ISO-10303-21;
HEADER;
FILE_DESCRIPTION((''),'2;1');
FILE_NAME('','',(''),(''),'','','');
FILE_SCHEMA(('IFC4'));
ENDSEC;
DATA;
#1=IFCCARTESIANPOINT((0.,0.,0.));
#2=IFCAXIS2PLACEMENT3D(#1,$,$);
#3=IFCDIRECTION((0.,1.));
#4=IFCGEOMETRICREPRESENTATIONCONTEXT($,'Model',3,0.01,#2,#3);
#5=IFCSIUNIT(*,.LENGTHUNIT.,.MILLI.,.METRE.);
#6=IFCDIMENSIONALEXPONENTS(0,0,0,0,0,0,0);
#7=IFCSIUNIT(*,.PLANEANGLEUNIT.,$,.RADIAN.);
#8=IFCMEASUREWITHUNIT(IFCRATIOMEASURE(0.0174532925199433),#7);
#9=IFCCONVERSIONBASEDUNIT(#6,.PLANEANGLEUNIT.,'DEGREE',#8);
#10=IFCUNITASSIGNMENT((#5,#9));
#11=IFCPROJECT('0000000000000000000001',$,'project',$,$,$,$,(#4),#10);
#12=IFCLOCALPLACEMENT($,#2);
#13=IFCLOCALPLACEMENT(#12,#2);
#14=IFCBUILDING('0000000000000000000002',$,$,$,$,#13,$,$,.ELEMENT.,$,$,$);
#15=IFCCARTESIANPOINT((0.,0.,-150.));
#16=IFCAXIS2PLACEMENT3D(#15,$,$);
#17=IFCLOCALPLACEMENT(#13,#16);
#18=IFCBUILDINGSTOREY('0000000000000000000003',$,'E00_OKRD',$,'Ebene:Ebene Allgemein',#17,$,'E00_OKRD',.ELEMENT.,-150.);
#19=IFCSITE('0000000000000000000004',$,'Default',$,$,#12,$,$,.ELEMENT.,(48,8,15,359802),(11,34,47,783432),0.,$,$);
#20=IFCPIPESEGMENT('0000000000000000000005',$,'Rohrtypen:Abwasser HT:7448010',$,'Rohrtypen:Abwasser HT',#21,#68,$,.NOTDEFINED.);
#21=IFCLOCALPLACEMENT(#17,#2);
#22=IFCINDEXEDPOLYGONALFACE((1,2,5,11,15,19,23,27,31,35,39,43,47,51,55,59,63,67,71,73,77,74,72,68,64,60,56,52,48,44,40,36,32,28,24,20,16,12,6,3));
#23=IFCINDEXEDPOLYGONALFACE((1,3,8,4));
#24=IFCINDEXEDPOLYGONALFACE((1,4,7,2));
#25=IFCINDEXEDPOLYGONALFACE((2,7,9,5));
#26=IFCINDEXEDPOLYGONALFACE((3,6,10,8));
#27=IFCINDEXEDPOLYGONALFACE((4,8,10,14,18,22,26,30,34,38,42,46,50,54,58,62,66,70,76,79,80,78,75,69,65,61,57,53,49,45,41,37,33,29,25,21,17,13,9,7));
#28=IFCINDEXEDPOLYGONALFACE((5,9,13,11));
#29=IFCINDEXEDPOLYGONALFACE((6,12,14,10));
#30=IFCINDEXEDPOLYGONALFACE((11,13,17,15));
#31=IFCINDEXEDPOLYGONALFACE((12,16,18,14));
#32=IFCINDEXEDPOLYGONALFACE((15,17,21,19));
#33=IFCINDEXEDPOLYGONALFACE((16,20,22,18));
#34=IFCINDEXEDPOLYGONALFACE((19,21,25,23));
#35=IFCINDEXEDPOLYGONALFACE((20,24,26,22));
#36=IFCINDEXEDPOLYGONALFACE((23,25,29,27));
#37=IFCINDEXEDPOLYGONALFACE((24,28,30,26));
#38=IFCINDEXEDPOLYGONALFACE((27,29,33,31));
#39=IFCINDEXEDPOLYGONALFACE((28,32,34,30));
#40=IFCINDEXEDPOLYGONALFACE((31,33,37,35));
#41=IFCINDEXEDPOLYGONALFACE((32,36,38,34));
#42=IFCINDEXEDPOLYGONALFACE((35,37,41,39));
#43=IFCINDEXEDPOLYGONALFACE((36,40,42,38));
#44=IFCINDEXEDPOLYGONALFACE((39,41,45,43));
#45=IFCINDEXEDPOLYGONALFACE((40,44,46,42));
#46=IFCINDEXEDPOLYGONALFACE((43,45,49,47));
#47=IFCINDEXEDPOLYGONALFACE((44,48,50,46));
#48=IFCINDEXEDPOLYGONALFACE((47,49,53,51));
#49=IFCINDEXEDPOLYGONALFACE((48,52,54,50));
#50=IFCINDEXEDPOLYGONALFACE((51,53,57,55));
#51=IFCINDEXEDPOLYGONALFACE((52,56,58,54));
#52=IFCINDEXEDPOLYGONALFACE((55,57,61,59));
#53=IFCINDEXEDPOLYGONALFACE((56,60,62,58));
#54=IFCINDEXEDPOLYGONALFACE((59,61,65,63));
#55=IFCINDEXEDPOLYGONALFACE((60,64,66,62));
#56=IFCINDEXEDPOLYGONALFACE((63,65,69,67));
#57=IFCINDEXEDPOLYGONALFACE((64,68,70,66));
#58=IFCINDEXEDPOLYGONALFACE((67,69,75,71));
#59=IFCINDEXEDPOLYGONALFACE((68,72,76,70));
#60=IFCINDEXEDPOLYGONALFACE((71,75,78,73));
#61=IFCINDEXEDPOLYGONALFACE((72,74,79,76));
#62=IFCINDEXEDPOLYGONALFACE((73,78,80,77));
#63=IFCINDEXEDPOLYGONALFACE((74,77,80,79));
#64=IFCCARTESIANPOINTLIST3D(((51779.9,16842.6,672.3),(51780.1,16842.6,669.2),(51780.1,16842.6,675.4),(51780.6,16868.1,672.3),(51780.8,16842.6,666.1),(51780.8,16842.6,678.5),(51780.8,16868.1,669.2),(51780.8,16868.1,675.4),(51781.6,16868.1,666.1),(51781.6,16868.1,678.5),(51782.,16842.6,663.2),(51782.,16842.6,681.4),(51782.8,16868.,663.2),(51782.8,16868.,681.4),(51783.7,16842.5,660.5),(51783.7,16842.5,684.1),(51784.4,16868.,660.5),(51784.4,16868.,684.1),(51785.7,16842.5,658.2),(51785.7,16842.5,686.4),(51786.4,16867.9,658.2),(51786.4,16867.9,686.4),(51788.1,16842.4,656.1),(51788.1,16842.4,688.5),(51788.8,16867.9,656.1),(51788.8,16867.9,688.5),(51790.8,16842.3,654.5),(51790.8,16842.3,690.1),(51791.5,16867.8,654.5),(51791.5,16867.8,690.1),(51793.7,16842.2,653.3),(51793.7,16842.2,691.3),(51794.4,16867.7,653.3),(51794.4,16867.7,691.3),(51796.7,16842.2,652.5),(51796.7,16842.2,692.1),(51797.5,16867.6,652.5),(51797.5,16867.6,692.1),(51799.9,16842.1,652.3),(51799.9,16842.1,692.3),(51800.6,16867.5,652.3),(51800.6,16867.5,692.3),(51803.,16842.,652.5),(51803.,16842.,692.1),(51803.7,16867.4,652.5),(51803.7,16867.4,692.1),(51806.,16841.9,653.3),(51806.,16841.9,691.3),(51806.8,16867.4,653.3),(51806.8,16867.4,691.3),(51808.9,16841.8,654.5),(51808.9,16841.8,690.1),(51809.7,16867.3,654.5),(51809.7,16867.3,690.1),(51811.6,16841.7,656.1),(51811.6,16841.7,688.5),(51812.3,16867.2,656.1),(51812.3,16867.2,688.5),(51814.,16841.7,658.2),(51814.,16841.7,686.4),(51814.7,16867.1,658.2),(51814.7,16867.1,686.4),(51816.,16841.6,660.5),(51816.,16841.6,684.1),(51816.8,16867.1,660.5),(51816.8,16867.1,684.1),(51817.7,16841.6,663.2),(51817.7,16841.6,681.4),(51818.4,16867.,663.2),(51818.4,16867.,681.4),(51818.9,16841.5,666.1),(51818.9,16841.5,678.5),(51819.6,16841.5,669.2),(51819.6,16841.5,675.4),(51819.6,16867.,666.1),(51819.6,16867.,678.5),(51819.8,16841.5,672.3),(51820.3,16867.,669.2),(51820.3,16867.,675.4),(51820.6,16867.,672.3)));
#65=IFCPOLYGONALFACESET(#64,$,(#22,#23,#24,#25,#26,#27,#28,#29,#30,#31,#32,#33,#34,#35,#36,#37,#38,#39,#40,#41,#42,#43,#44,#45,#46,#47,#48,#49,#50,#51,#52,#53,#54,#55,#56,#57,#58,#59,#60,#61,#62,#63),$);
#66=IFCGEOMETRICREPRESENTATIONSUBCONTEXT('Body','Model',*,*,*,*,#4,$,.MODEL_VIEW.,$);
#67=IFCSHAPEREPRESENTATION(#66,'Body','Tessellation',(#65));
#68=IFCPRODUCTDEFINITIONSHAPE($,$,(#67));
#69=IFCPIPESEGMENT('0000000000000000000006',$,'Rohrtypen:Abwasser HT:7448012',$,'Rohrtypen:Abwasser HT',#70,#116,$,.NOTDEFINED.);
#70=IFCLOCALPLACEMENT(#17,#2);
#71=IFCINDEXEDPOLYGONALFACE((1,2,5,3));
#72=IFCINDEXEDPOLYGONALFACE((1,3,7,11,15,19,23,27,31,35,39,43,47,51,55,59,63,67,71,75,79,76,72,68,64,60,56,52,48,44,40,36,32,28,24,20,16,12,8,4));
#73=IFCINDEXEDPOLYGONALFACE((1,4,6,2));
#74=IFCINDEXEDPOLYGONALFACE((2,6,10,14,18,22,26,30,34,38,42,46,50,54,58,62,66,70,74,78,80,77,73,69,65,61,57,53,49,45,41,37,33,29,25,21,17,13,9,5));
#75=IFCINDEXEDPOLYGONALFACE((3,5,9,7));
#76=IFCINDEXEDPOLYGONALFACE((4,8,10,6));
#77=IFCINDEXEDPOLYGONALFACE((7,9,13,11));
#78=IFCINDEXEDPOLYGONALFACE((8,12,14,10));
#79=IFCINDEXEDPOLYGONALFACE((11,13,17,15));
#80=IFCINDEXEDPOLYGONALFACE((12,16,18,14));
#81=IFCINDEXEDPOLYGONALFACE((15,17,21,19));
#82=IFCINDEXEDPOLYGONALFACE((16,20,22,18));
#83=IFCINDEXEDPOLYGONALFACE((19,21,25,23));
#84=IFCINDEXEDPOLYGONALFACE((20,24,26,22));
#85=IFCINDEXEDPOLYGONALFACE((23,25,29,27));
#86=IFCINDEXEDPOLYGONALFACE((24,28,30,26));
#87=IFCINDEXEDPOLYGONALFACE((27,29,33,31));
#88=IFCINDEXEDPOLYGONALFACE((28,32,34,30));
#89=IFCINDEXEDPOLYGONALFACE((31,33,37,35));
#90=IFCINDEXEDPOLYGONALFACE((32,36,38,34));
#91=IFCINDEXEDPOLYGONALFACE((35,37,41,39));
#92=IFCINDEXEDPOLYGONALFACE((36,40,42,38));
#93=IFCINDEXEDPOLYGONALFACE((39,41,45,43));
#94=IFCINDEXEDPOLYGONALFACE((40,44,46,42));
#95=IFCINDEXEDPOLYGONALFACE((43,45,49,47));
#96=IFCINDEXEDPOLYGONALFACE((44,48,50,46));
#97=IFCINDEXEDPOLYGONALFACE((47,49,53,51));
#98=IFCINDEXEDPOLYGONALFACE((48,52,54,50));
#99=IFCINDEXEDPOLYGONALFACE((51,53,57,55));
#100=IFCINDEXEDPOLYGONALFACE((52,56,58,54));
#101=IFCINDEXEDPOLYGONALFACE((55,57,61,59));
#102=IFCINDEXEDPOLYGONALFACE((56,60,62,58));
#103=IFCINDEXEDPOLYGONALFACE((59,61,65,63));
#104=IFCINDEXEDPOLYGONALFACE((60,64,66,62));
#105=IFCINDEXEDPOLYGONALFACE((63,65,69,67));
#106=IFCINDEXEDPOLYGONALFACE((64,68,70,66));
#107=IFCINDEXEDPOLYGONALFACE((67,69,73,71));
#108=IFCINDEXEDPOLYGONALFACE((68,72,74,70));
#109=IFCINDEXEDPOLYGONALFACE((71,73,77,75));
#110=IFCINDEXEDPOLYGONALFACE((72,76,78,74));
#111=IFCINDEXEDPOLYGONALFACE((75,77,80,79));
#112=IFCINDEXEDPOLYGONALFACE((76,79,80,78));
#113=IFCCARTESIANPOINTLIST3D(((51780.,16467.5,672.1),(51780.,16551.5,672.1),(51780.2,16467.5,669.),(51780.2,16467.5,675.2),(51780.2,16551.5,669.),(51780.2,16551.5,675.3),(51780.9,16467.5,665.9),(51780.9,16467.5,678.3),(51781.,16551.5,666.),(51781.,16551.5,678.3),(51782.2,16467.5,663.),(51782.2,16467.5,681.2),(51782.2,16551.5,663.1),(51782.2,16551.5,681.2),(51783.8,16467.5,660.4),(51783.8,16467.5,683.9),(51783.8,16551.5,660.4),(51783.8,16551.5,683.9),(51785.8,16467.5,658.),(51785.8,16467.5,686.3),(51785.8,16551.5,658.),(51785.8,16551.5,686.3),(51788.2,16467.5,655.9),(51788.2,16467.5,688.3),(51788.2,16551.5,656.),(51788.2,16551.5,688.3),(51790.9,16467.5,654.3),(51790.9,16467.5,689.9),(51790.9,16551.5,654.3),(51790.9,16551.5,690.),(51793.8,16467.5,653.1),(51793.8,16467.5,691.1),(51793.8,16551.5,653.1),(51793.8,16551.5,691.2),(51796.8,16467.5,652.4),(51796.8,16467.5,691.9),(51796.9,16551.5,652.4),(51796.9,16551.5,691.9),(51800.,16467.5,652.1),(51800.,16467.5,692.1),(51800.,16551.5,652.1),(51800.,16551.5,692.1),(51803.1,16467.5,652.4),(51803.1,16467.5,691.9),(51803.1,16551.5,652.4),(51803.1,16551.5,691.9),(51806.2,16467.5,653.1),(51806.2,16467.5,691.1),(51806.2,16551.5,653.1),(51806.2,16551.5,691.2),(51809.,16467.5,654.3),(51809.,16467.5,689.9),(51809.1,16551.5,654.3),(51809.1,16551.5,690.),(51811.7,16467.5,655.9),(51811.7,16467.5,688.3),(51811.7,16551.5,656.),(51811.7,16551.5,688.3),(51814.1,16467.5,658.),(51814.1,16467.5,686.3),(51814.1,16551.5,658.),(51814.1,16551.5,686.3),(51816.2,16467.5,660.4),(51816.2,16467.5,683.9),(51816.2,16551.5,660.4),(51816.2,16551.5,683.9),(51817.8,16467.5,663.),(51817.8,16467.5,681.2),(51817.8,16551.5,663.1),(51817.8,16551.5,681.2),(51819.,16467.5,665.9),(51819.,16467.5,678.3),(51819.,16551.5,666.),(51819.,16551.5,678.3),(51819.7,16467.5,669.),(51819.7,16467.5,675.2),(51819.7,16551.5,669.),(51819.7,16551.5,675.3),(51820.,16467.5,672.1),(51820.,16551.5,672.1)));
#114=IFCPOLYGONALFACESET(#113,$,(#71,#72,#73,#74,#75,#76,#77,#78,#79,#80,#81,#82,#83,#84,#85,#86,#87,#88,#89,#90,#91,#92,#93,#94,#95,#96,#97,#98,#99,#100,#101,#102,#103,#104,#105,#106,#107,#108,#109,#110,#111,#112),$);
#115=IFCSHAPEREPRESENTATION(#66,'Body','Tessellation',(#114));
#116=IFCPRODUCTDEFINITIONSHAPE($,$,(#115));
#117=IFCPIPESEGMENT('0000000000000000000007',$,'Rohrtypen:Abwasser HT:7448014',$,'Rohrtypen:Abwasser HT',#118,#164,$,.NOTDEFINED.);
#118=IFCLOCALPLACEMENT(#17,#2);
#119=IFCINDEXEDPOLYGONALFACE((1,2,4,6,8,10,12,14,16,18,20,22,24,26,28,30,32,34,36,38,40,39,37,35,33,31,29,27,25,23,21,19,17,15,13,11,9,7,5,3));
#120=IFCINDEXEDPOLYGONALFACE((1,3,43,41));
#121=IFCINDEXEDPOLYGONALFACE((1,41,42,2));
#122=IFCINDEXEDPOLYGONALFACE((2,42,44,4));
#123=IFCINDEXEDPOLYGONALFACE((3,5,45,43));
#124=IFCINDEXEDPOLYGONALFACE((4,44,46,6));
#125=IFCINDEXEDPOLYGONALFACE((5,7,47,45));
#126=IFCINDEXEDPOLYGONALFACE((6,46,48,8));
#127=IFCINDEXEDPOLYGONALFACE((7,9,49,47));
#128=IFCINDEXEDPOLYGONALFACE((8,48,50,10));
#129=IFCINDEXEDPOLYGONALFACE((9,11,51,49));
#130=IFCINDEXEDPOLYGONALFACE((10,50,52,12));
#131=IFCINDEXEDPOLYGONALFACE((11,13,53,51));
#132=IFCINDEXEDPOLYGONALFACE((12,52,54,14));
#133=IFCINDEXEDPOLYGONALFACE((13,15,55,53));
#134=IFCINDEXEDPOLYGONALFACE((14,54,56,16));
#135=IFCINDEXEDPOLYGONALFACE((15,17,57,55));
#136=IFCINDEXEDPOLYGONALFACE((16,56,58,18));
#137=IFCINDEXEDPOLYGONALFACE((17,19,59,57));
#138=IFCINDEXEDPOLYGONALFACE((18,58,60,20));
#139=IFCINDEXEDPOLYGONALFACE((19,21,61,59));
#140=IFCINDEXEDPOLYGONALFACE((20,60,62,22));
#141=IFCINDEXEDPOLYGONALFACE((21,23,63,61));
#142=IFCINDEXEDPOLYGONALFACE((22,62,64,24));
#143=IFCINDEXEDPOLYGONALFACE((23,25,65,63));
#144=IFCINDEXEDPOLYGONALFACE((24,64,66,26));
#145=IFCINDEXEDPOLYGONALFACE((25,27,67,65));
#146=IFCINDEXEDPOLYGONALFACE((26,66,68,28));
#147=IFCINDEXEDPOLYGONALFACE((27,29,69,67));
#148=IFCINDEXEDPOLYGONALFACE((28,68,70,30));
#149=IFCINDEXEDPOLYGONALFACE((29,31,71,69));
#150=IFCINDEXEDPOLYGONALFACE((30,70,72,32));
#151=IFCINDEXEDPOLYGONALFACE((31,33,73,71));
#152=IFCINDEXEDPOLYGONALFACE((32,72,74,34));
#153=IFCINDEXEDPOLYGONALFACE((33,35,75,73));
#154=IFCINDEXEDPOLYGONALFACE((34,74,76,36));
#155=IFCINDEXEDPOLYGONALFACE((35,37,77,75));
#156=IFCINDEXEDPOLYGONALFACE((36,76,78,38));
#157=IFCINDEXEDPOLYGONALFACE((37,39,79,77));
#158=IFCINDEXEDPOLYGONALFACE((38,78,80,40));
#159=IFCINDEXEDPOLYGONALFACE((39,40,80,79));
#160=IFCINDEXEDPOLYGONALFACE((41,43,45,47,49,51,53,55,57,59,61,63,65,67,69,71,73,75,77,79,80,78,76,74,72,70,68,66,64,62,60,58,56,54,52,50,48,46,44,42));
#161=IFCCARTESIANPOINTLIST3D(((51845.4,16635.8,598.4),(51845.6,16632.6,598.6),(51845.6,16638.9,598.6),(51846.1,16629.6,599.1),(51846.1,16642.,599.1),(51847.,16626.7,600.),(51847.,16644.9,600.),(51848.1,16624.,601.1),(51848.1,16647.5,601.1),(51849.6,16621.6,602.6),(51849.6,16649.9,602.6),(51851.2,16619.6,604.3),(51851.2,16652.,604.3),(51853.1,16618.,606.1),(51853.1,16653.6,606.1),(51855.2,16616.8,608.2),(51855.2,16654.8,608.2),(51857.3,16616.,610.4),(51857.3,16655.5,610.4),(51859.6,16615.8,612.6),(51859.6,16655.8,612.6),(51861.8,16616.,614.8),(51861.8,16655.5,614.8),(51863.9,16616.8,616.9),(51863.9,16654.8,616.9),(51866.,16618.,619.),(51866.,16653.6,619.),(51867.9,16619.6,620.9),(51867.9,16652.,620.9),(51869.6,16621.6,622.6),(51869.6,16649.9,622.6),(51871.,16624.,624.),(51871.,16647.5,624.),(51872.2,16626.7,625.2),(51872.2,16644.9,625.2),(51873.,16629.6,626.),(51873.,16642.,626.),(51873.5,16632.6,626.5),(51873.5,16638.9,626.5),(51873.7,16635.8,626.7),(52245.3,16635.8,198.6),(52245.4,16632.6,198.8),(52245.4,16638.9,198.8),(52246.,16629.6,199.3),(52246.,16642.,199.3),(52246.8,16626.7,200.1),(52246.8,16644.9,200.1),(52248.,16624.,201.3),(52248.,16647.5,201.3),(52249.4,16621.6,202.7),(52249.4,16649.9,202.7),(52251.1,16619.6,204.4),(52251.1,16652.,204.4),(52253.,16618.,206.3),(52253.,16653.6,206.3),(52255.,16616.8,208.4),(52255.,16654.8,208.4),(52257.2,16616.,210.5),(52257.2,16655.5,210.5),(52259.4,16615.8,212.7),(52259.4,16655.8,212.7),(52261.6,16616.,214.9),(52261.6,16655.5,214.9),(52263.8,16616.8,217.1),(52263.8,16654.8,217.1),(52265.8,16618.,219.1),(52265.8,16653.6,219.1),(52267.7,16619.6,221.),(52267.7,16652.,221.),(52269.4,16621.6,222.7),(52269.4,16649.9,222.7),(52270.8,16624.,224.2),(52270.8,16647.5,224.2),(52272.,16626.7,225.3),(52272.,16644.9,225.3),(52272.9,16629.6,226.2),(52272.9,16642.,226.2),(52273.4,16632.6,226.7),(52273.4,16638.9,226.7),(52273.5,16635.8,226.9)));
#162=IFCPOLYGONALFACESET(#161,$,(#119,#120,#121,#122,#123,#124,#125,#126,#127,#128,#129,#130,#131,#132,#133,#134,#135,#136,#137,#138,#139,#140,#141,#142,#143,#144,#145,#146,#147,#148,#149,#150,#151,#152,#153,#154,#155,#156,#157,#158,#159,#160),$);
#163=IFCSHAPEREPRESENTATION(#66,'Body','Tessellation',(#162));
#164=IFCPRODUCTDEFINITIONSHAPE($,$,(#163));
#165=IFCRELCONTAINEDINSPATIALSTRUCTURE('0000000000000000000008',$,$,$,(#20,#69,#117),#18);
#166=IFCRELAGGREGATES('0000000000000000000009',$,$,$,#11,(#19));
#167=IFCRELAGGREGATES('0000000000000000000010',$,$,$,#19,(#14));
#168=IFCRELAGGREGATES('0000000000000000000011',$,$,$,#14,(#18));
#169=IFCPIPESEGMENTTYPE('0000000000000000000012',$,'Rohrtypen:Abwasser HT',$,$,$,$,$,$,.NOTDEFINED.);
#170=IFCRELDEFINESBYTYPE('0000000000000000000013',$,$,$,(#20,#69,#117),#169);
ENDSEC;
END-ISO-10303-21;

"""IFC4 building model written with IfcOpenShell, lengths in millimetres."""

from ifc_helpers import new_model, entity, si_unit, converted_unit, direction, frame, origin, place, context, subcontext, project, spatial, indexed_curve, outline, extrude, type_object, element, save


model = new_model("IFC4")

# Units and contexts
model_context = context("Model", 3, precision=0.01, world=origin(), true_north=direction((0.0, 1.0)))
body_context = subcontext(model_context, "Body", "Model", "MODEL_VIEW")
ifc_project = project(units=[si_unit("LENGTHUNIT", "METRE", prefix="MILLI"), converted_unit("PLANEANGLEUNIT", "DEGREE", entity("IfcRatioMeasure", 0.0174532925199433), si_unit("PLANEANGLEUNIT", "RADIAN"), dimensions=[0, 0, 0, 0, 0, 0, 0])], contexts=[model_context])

# Site, building, storey
site_placement = place(None, origin())
site = spatial("IfcSite", under=ifc_project, at=site_placement, Name="Default", CompositionType="ELEMENT", RefLatitude=(48, 8, 15, 359802), RefLongitude=(11, 34, 47, 783432), RefElevation=0.0)
building_placement = place(site_placement, origin())
building = spatial("IfcBuilding", under=site, at=building_placement, CompositionType="ELEMENT")
storey_placement = place(building_placement, frame((0.0, 0.0, -150.0)))
storey = spatial("IfcBuildingStorey", under=building, at=storey_placement, Name="E00_OKRD", ObjectType="Ebene:Ebene Allgemein", LongName="E00_OKRD", CompositionType="ELEMENT", Elevation=-150.0)

# Pipe segments
pipe_segment_type_1 = type_object("IfcPipeSegmentType", Name="Rohrtypen:Abwasser HT", PredefinedType="NOTDEFINED")
pipe_segment_1_placement = place(storey_placement, origin())
element("IfcPipeSegment", 1, at=pipe_segment_1_placement, inside=storey, type_object=pipe_segment_type_1, Name="Rohrtypen:Abwasser HT:7448010", ObjectType="Rohrtypen:Abwasser HT", PredefinedType="NOTDEFINED", context=body_context, shape_type="SweptSolid", body=[
    extrude(outline(indexed_curve([(20.0, 0.0), (19.8, 3.1), (19.0, 6.2), (17.8, 9.1), (16.2, 11.8), (14.1, 14.1), (11.8, 16.2), (9.1, 17.8), (6.2, 19.0), (3.1, 19.8), (0.0, 20.0), (-3.1, 19.8), (-6.2, 19.0), (-9.1, 17.8), (-11.8, 16.2), (-14.1, 14.1), (-16.2, 11.8), (-17.8, 9.1), (-19.0, 6.2), (-19.8, 3.1), (-20.0, 0.0), (-19.8, -3.1), (-19.0, -6.2), (-17.8, -9.1), (-16.2, -11.8), (-14.1, -14.1), (-11.8, -16.2), (-9.1, -17.8), (-6.2, -19.0), (-3.1, -19.8), (0.0, -20.0), (3.1, -19.8), (6.2, -19.0), (9.1, -17.8), (11.8, -16.2), (14.1, -14.1), (16.2, -11.8), (17.8, -9.1), (19.0, -6.2), (19.8, -3.1), (20.0, 0.0)], self_intersect=False)), frame((51799.9, 16842.1, 672.3), z_axis=(0.02857, 0.999592, 0.0), x_axis=(-0.999592, 0.02857, 0.0)), (0.0, 0.0, 1.0), 25.5),
])
pipe_segment_2_placement = place(storey_placement, origin())
element("IfcPipeSegment", 2, at=pipe_segment_2_placement, inside=storey, type_object=pipe_segment_type_1, Name="Rohrtypen:Abwasser HT:7448012", ObjectType="Rohrtypen:Abwasser HT", PredefinedType="NOTDEFINED", context=body_context, shape_type="SweptSolid", body=[
    extrude(outline(indexed_curve([(20.0, 0.0), (19.8, 3.1), (19.0, 6.2), (17.8, 9.1), (16.2, 11.8), (14.1, 14.1), (11.8, 16.2), (9.1, 17.8), (6.2, 19.0), (3.1, 19.8), (0.0, 20.0), (-3.1, 19.8), (-6.2, 19.0), (-9.1, 17.8), (-11.8, 16.2), (-14.1, 14.1), (-16.2, 11.8), (-17.8, 9.1), (-19.0, 6.2), (-19.8, 3.1), (-20.0, 0.0), (-19.8, -3.1), (-19.0, -6.2), (-17.8, -9.1), (-16.2, -11.8), (-14.1, -14.1), (-11.8, -16.2), (-9.1, -17.8), (-6.2, -19.0), (-3.1, -19.8), (0.0, -20.0), (3.1, -19.8), (6.2, -19.0), (9.1, -17.8), (11.8, -16.2), (14.1, -14.1), (16.2, -11.8), (17.8, -9.1), (19.0, -6.2), (19.8, -3.1), (20.0, 0.0)], self_intersect=False)), frame((51800.0, 16467.5, 672.1), z_axis=(0.000227, 1.0, 0.00027), x_axis=(1.0, -0.000227, 0.0)), (0.0, 0.0, 1.0), 84.0),
])
pipe_segment_3_placement = place(storey_placement, origin())
element("IfcPipeSegment", 3, at=pipe_segment_3_placement, inside=storey, type_object=pipe_segment_type_1, Name="Rohrtypen:Abwasser HT:7448014", ObjectType="Rohrtypen:Abwasser HT", PredefinedType="NOTDEFINED", context=body_context, shape_type="SweptSolid", body=[
    extrude(outline(indexed_curve([(20.0, 0.0), (19.8, 3.1), (19.0, 6.2), (17.8, 9.1), (16.2, 11.8), (14.1, 14.1), (11.8, 16.2), (9.1, 17.8), (6.2, 19.0), (3.1, 19.8), (0.0, 20.0), (-3.1, 19.8), (-6.2, 19.0), (-9.1, 17.8), (-11.8, 16.2), (-14.1, 14.1), (-16.2, 11.8), (-17.8, 9.1), (-19.0, 6.2), (-19.8, 3.1), (-20.0, 0.0), (-19.8, -3.1), (-19.0, -6.2), (-17.8, -9.1), (-16.2, -11.8), (-14.1, -14.1), (-11.8, -16.2), (-9.1, -17.8), (-6.2, -19.0), (-3.1, -19.8), (0.0, -20.0), (3.1, -19.8), (6.2, -19.0), (9.1, -17.8), (11.8, -16.2), (14.1, -14.1), (16.2, -11.8), (17.8, -9.1), (19.0, -6.2), (19.8, -3.1), (20.0, 0.0)], self_intersect=False)), frame((51859.6, 16635.8, 612.6), z_axis=(0.707107, 0.0, -0.707107), x_axis=(0.0, 1.0, 0.0)), (0.0, 0.0, 1.0), 565.5),
])

save(model, "model.ifc")
